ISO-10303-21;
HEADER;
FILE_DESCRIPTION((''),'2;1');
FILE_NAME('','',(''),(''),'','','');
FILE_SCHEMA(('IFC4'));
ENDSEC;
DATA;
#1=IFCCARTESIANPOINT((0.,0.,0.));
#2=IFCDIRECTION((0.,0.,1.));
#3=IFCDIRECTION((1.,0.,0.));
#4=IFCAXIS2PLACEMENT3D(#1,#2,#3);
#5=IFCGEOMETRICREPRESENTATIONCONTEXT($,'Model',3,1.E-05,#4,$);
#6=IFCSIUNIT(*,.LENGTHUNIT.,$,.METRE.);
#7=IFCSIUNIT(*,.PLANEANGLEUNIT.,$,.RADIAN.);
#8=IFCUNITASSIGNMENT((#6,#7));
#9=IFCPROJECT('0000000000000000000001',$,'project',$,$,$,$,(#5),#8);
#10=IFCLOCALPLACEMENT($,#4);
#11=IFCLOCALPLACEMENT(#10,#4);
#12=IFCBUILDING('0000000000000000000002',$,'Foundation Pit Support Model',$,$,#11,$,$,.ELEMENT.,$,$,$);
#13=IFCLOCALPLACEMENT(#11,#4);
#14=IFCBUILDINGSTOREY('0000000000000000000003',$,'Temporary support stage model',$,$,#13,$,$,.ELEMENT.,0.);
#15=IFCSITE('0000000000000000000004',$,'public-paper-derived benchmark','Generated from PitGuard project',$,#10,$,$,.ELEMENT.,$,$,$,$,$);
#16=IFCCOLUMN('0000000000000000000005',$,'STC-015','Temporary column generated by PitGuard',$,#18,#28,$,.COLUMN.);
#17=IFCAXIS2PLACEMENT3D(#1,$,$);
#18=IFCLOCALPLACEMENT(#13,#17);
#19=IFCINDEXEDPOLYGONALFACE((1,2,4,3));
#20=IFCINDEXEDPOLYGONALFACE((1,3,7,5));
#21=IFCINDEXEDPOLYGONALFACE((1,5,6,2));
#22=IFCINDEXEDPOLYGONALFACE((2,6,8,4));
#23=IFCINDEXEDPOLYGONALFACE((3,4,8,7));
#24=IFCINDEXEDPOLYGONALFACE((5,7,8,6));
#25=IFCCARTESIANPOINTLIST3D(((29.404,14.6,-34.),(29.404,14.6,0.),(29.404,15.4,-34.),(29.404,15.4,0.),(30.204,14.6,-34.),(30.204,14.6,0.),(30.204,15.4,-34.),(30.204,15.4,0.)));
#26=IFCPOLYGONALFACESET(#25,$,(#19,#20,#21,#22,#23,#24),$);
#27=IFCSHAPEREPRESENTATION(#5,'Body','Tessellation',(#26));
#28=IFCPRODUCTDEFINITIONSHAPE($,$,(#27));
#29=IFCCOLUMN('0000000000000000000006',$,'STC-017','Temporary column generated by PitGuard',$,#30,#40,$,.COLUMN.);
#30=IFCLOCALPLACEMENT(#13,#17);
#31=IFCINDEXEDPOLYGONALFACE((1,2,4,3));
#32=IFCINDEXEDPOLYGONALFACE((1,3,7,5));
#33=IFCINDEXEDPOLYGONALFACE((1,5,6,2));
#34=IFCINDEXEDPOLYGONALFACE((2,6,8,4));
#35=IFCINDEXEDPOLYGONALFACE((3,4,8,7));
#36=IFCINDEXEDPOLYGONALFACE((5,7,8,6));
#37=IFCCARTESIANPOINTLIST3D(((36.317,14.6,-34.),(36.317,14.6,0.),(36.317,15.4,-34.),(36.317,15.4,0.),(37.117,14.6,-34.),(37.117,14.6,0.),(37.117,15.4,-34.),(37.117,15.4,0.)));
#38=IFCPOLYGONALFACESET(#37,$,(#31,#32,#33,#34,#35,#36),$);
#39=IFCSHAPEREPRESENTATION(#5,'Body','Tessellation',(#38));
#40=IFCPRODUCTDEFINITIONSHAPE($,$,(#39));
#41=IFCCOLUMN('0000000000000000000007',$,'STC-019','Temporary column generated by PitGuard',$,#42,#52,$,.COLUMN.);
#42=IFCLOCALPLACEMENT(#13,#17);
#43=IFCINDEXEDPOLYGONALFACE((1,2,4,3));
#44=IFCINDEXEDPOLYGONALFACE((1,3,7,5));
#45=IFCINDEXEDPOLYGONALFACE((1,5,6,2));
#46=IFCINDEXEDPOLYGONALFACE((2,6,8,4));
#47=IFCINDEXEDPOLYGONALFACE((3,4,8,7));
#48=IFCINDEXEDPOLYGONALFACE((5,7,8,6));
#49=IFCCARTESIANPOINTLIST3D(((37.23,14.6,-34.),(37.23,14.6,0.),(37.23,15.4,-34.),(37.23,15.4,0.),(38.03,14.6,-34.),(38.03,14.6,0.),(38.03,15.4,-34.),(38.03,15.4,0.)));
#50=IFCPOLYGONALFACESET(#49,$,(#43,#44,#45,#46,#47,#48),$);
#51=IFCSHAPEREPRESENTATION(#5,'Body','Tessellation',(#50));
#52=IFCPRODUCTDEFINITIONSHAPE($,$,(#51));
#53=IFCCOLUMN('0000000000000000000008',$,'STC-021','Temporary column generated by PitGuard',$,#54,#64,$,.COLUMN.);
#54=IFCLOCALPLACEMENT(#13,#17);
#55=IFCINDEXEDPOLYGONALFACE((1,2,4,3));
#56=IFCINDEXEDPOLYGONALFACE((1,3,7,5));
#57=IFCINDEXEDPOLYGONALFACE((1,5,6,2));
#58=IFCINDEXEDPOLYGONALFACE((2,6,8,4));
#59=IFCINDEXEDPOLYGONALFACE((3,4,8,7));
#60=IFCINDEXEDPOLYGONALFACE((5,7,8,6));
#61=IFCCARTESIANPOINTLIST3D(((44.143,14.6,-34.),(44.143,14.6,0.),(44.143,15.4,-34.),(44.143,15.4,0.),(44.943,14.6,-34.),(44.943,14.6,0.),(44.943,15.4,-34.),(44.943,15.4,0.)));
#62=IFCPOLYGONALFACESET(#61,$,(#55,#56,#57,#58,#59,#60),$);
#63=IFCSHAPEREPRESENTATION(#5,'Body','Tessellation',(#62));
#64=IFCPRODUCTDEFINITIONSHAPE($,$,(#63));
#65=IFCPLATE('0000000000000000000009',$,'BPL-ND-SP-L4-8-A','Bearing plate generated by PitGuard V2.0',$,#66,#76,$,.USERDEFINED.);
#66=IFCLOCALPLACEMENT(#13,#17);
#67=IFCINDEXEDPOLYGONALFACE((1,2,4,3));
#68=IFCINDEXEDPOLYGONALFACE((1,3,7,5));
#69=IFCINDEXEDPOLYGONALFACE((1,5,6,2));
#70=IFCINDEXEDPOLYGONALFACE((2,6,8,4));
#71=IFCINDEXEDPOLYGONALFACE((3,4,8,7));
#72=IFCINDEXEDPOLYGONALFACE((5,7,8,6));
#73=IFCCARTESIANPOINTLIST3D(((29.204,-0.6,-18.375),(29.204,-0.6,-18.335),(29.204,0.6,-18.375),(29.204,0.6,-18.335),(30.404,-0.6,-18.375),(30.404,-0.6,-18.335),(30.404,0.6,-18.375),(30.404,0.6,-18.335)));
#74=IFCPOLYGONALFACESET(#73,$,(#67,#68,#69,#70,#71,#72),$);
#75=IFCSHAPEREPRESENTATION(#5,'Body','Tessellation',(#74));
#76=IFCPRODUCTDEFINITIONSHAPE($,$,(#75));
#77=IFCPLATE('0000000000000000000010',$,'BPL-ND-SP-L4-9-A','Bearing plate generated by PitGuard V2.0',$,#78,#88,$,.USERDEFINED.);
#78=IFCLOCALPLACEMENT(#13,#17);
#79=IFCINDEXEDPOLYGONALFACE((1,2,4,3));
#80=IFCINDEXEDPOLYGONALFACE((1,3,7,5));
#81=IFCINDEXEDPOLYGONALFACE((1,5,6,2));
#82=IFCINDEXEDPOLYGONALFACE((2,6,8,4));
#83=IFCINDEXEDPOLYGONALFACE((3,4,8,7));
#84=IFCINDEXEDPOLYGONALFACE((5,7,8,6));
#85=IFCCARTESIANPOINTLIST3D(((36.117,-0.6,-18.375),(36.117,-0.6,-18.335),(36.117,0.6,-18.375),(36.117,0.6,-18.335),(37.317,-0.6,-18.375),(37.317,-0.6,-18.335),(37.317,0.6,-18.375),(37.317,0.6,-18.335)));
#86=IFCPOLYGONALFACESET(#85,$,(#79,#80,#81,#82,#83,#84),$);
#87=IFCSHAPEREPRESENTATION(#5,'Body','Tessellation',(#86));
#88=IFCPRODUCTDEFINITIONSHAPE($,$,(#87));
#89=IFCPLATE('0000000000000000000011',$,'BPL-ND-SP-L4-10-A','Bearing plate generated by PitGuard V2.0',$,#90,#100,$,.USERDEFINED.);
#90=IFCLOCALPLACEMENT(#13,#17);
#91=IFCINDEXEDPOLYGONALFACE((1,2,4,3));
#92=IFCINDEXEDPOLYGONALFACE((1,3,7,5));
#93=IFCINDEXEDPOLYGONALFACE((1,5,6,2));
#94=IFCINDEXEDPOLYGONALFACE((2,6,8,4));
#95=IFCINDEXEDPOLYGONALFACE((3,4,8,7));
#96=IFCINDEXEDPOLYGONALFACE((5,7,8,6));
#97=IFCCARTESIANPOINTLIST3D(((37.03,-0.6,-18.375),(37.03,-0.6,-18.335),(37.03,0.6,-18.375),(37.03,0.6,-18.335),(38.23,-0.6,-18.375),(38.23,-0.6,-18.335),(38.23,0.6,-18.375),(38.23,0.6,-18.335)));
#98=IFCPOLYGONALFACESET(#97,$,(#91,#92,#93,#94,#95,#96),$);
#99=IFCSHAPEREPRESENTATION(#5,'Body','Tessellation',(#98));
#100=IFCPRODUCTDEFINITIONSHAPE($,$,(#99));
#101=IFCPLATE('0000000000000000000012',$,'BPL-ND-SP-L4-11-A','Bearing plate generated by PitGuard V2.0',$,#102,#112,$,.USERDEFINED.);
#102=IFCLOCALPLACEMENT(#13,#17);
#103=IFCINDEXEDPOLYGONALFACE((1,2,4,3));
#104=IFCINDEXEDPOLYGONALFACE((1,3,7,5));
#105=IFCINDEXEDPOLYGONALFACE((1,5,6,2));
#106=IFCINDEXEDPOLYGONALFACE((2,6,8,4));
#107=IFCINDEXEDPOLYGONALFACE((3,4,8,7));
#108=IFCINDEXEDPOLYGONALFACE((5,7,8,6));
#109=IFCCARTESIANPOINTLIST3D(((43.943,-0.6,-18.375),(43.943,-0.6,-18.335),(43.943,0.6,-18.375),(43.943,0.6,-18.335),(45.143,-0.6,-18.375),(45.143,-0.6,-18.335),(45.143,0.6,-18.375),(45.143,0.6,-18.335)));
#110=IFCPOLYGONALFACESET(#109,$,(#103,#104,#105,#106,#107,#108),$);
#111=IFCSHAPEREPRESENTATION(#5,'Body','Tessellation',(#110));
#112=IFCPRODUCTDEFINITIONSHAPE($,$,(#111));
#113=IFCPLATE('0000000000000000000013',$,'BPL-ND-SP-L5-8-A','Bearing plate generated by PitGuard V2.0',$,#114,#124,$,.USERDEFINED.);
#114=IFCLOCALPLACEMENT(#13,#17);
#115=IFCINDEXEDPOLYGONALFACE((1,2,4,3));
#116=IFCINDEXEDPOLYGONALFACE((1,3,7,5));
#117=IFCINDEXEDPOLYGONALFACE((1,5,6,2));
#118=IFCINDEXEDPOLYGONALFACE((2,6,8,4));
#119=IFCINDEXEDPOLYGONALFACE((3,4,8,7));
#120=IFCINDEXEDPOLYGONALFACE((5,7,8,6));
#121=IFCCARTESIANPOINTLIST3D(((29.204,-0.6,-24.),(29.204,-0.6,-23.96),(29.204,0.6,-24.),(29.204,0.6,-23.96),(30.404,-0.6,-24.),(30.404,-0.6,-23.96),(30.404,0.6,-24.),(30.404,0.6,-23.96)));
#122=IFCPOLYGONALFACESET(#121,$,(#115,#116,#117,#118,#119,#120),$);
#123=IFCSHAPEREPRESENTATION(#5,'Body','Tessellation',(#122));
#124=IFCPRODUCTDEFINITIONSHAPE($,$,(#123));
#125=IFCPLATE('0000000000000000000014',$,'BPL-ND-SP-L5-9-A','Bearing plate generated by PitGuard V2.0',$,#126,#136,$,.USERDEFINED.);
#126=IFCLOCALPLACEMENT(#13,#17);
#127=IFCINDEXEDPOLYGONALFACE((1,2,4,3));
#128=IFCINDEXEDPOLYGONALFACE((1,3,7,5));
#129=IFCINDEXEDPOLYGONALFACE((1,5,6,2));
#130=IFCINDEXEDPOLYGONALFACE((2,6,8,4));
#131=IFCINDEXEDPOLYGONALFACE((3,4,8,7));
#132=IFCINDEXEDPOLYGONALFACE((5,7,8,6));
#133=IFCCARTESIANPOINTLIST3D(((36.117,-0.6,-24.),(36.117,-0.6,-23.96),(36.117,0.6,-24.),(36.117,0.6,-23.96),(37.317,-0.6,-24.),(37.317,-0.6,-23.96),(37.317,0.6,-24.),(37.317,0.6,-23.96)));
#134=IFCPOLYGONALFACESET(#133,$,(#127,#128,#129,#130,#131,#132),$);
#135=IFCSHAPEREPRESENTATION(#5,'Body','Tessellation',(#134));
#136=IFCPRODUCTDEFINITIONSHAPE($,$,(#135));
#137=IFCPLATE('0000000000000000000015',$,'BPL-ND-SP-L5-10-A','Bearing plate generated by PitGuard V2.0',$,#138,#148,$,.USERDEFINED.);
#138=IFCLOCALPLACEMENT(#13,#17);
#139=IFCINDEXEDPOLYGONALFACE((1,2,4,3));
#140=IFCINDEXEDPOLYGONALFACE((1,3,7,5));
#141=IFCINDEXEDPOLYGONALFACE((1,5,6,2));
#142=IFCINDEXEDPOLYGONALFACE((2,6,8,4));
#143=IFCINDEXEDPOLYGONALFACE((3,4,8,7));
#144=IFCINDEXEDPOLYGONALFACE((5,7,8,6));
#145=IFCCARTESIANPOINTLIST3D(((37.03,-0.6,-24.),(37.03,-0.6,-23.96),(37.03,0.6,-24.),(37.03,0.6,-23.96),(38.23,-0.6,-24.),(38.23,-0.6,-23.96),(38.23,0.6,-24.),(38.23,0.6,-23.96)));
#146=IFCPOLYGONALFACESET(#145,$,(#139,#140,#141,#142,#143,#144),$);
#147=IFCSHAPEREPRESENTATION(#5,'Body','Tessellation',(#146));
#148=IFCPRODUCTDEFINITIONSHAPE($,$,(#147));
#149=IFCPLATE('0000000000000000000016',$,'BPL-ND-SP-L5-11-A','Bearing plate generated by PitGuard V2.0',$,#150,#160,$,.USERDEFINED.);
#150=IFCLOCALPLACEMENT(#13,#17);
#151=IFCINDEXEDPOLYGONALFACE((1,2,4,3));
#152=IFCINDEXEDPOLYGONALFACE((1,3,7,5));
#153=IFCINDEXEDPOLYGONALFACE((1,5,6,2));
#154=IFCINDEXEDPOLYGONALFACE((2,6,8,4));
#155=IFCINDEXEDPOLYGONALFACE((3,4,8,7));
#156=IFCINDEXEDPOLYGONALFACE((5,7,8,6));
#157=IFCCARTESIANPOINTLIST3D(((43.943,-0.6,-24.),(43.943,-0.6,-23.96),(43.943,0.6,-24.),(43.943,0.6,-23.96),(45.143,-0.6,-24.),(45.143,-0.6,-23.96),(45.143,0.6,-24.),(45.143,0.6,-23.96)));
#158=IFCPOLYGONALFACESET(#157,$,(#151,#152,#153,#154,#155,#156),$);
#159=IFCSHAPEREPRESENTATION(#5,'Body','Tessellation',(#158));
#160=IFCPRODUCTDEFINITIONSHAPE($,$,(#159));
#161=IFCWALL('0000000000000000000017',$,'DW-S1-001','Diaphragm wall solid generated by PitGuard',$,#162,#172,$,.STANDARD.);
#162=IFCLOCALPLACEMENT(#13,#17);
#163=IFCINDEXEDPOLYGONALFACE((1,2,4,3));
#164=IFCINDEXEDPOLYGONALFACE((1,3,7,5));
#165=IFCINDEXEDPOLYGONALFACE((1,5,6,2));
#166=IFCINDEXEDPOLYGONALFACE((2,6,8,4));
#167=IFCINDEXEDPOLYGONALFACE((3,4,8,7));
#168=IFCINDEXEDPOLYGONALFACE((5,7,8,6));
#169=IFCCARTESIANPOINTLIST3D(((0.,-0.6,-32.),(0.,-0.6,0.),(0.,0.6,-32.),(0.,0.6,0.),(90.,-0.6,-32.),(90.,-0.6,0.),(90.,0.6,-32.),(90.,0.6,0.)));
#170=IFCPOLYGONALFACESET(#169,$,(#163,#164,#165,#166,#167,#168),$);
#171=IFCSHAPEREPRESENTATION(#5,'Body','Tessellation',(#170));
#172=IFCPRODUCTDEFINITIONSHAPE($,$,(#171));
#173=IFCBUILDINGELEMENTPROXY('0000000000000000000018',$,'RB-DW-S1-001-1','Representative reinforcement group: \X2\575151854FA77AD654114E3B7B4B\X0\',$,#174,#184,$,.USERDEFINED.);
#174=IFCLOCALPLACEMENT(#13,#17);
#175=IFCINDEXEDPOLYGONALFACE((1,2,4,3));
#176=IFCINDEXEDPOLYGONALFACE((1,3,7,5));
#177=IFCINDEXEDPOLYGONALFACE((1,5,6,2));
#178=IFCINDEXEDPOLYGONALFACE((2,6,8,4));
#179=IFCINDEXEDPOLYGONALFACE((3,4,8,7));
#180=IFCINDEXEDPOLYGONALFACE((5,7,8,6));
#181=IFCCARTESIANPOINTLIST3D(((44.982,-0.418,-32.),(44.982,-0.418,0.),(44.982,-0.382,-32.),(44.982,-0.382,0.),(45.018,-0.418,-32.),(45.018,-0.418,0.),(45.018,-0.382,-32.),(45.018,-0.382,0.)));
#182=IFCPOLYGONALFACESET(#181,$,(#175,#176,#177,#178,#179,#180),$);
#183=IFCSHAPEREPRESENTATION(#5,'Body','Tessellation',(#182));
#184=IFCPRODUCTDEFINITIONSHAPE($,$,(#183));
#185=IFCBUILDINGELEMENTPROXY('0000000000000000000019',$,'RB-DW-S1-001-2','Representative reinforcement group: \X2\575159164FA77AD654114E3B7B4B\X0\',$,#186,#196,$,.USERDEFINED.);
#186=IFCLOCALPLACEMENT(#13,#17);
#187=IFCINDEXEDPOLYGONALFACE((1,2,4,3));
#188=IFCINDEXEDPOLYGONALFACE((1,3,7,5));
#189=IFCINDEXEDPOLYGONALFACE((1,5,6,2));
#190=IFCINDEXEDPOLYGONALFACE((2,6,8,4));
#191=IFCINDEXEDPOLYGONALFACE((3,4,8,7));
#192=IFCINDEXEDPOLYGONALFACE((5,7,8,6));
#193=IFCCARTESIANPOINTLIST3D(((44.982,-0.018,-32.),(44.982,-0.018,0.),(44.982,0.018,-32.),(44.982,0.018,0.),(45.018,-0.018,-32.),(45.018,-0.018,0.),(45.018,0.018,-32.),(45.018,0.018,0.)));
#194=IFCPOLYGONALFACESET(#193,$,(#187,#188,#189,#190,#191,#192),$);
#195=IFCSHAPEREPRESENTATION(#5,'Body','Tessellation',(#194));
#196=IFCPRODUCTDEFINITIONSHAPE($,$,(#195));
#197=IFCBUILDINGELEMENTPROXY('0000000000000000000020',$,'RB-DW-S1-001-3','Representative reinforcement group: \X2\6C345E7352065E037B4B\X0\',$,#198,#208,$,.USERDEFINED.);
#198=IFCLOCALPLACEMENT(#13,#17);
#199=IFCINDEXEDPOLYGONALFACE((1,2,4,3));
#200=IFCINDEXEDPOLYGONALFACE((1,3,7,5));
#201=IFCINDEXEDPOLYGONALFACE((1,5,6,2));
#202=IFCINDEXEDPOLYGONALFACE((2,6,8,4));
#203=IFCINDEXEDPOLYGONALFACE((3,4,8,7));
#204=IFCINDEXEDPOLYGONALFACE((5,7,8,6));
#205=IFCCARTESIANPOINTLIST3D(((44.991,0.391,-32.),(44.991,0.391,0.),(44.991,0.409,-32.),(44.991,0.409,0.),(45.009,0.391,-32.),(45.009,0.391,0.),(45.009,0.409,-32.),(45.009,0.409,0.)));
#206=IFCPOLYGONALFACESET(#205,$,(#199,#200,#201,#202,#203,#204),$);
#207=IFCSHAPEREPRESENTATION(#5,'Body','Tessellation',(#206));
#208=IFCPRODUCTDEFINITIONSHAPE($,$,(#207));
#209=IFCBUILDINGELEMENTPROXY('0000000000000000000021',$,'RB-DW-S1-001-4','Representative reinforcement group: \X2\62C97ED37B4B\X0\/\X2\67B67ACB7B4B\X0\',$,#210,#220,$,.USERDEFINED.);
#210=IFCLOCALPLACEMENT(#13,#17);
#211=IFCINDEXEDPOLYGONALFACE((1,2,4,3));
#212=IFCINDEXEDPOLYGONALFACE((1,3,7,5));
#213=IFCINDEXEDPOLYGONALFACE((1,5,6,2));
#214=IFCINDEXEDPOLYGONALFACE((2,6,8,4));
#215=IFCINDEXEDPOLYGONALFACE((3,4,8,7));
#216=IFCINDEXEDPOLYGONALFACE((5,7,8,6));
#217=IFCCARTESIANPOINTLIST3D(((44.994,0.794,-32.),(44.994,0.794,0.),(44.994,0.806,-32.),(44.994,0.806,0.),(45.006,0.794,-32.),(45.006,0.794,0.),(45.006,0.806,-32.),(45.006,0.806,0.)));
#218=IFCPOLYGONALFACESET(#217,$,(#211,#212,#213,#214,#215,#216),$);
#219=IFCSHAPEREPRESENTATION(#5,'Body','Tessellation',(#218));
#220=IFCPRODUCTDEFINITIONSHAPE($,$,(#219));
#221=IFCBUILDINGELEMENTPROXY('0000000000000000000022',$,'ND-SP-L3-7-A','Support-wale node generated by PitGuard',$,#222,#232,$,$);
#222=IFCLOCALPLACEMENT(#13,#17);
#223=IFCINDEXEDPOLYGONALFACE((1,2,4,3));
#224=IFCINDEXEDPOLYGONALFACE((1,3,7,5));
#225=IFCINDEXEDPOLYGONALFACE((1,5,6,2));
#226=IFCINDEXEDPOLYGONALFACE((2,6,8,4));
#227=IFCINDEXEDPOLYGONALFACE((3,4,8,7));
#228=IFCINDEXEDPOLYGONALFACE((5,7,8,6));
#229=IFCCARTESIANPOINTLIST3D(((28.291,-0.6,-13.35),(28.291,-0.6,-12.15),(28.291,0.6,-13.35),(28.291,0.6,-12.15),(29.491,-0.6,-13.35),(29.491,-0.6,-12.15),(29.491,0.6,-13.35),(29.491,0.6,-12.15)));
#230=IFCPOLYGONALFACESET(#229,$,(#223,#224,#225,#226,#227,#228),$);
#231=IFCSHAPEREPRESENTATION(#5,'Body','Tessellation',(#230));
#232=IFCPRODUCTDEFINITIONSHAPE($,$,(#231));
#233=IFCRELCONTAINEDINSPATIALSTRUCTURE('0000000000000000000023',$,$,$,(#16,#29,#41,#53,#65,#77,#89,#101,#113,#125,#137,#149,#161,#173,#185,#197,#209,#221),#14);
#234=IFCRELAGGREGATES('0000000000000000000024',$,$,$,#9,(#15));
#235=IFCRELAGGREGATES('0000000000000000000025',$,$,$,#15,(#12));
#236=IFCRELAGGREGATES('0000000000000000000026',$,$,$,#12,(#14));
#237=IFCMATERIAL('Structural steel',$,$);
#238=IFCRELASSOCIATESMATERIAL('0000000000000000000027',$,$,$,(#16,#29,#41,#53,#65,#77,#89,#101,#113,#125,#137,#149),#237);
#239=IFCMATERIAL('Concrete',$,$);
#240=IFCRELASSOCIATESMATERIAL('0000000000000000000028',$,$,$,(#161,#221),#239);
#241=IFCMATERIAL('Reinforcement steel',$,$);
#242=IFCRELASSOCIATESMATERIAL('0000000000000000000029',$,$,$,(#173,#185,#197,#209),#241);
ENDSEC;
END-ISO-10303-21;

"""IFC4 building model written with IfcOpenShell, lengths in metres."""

from ifc_helpers import new_model, si_unit, frame, origin_with_axes, origin_2d, place, context, project, spatial, rectangle, extrude, material, element, save


model = new_model("IFC4")

# Units and contexts
model_context = context("Model", 3, precision=1e-05, world=origin_with_axes())
ifc_project = project(units=[si_unit("LENGTHUNIT", "METRE"), si_unit("PLANEANGLEUNIT", "RADIAN")], contexts=[model_context])

# Site, building, storey
site_placement = place(None, origin_with_axes())
site = spatial("IfcSite", under=ifc_project, at=site_placement, Name="public-paper-derived benchmark", Description="Generated from PitGuard project", CompositionType="ELEMENT")
building_placement = place(site_placement, origin_with_axes())
building = spatial("IfcBuilding", under=site, at=building_placement, Name="Foundation Pit Support Model", CompositionType="ELEMENT")
storey_placement = place(building_placement, origin_with_axes())
storey = spatial("IfcBuildingStorey", under=building, at=storey_placement, Name="Temporary support stage model", CompositionType="ELEMENT", Elevation=0.0)

# Columns
ifc_material_1 = material(Name="Structural steel")
for number, where, z_axis, x_axis, name in (
    (1, (29.804, 15.0, -34.0), (0.0, 0.0, 1.0), (1.0, 0.0, 0.0), "STC-015"),
    (2, (36.717, 15.0, -34.0), (0.0, 0.0, 1.0), (1.0, 0.0, 0.0), "STC-017"),
    (3, (37.63, 15.0, -34.0), (0.0, 0.0, 1.0), (1.0, 0.0, 0.0), "STC-019"),
    (4, (44.543, 15.0, -34.0), (0.0, 0.0, 1.0), (1.0, 0.0, 0.0), "STC-021"),
):
    element("IfcColumn", number, at=place(storey_placement, frame(where, z_axis=z_axis, x_axis=x_axis)), inside=storey, material=ifc_material_1, Name=name, Description="Temporary column generated by PitGuard", PredefinedType="COLUMN", context=model_context, shape_type="SweptSolid", body=[
        extrude(rectangle(XDim=0.8, YDim=0.8, at=origin_2d()), origin_with_axes(), (0.0, 0.0, 1.0), 34.0),
    ])

# Plates
for number, where, z_axis, x_axis, name in (
    (5, (29.804, 0.0, -18.375), (0.0, 0.0, 1.0), (1.0, 0.0, 0.0), "BPL-ND-SP-L4-8-A"),
    (6, (36.717, 0.0, -18.375), (0.0, 0.0, 1.0), (1.0, 0.0, 0.0), "BPL-ND-SP-L4-9-A"),
    (7, (37.63, 0.0, -18.375), (0.0, 0.0, 1.0), (1.0, 0.0, 0.0), "BPL-ND-SP-L4-10-A"),
    (8, (44.543, 0.0, -18.375), (0.0, 0.0, 1.0), (1.0, 0.0, 0.0), "BPL-ND-SP-L4-11-A"),
    (9, (29.804, 0.0, -24.0), (0.0, 0.0, 1.0), (1.0, 0.0, 0.0), "BPL-ND-SP-L5-8-A"),
    (10, (36.717, 0.0, -24.0), (0.0, 0.0, 1.0), (1.0, 0.0, 0.0), "BPL-ND-SP-L5-9-A"),
    (11, (37.63, 0.0, -24.0), (0.0, 0.0, 1.0), (1.0, 0.0, 0.0), "BPL-ND-SP-L5-10-A"),
    (12, (44.543, 0.0, -24.0), (0.0, 0.0, 1.0), (1.0, 0.0, 0.0), "BPL-ND-SP-L5-11-A"),
):
    element("IfcPlate", number, at=place(storey_placement, frame(where, z_axis=z_axis, x_axis=x_axis)), inside=storey, material=ifc_material_1, Name=name, Description="Bearing plate generated by PitGuard V2.0", PredefinedType="USERDEFINED", context=model_context, shape_type="SweptSolid", body=[
        extrude(rectangle(XDim=1.2, YDim=1.2, at=origin_2d()), origin_with_axes(), (0.0, 0.0, 1.0), 0.04),
    ])

# Wall
ifc_material_2 = material(Name="Concrete")
wall_placement = place(storey_placement, frame((45.0, 0.0, -32.0), z_axis=(0.0, 0.0, 1.0), x_axis=(1.0, 0.0, 0.0)))
element("IfcWall", 13, at=wall_placement, inside=storey, material=ifc_material_2, Name="DW-S1-001", Description="Diaphragm wall solid generated by PitGuard", PredefinedType="STANDARD", context=model_context, shape_type="SweptSolid", body=[
    extrude(rectangle(XDim=90.0, YDim=1.2, at=origin_2d()), origin_with_axes(), (0.0, 0.0, 1.0), 32.0),
])

# Building element proxies
ifc_material_3 = material(Name="Reinforcement steel")
for number, where, z_axis, x_axis, name, description in (
    (14, (45.0, -0.4, -32.0), (0.0, 0.0, 1.0), (1.0, 0.0, 0.0), "RB-DW-S1-001-1", "Representative reinforcement group: 坑内侧竖向主筋"),
    (15, (45.0, 0.0, -32.0), (0.0, 0.0, 1.0), (1.0, 0.0, 0.0), "RB-DW-S1-001-2", "Representative reinforcement group: 坑外侧竖向主筋"),
):
    element("IfcBuildingElementProxy", number, at=place(storey_placement, frame(where, z_axis=z_axis, x_axis=x_axis)), inside=storey, material=ifc_material_3, Name=name, Description=description, PredefinedType="USERDEFINED", context=model_context, shape_type="SweptSolid", body=[
        extrude(rectangle(XDim=0.036, YDim=0.036, at=origin_2d()), origin_with_axes(), (0.0, 0.0, 1.0), 32.0),
    ])
proxy_1_placement = place(storey_placement, frame((45.0, 0.4, -32.0), z_axis=(0.0, 0.0, 1.0), x_axis=(1.0, 0.0, 0.0)))
element("IfcBuildingElementProxy", 16, at=proxy_1_placement, inside=storey, material=ifc_material_3, Name="RB-DW-S1-001-3", Description="Representative reinforcement group: 水平分布筋", PredefinedType="USERDEFINED", context=model_context, shape_type="SweptSolid", body=[
    extrude(rectangle(XDim=0.018, YDim=0.018, at=origin_2d()), origin_with_axes(), (0.0, 0.0, 1.0), 32.0),
])
proxy_2_placement = place(storey_placement, frame((45.0, 0.8, -32.0), z_axis=(0.0, 0.0, 1.0), x_axis=(1.0, 0.0, 0.0)))
element("IfcBuildingElementProxy", 17, at=proxy_2_placement, inside=storey, material=ifc_material_3, Name="RB-DW-S1-001-4", Description="Representative reinforcement group: 拉结筋/架立筋", PredefinedType="USERDEFINED", context=model_context, shape_type="SweptSolid", body=[
    extrude(rectangle(XDim=0.012, YDim=0.012, at=origin_2d()), origin_with_axes(), (0.0, 0.0, 1.0), 32.0),
])
for number, where, z_axis, x_axis, name in (
    (18, (28.891, 0.0, -13.35), (0.0, 0.0, 1.0), (1.0, 0.0, 0.0), "ND-SP-L3-7-A"),
):
    element("IfcBuildingElementProxy", number, at=place(storey_placement, frame(where, z_axis=z_axis, x_axis=x_axis)), inside=storey, material=ifc_material_2, Name=name, Description="Support-wale node generated by PitGuard", context=model_context, shape_type="SweptSolid", body=[
        extrude(rectangle(XDim=1.2, YDim=1.2, at=origin_2d()), origin_with_axes(), (0.0, 0.0, 1.0), 1.2),
    ])

save(model, "model.ifc")
